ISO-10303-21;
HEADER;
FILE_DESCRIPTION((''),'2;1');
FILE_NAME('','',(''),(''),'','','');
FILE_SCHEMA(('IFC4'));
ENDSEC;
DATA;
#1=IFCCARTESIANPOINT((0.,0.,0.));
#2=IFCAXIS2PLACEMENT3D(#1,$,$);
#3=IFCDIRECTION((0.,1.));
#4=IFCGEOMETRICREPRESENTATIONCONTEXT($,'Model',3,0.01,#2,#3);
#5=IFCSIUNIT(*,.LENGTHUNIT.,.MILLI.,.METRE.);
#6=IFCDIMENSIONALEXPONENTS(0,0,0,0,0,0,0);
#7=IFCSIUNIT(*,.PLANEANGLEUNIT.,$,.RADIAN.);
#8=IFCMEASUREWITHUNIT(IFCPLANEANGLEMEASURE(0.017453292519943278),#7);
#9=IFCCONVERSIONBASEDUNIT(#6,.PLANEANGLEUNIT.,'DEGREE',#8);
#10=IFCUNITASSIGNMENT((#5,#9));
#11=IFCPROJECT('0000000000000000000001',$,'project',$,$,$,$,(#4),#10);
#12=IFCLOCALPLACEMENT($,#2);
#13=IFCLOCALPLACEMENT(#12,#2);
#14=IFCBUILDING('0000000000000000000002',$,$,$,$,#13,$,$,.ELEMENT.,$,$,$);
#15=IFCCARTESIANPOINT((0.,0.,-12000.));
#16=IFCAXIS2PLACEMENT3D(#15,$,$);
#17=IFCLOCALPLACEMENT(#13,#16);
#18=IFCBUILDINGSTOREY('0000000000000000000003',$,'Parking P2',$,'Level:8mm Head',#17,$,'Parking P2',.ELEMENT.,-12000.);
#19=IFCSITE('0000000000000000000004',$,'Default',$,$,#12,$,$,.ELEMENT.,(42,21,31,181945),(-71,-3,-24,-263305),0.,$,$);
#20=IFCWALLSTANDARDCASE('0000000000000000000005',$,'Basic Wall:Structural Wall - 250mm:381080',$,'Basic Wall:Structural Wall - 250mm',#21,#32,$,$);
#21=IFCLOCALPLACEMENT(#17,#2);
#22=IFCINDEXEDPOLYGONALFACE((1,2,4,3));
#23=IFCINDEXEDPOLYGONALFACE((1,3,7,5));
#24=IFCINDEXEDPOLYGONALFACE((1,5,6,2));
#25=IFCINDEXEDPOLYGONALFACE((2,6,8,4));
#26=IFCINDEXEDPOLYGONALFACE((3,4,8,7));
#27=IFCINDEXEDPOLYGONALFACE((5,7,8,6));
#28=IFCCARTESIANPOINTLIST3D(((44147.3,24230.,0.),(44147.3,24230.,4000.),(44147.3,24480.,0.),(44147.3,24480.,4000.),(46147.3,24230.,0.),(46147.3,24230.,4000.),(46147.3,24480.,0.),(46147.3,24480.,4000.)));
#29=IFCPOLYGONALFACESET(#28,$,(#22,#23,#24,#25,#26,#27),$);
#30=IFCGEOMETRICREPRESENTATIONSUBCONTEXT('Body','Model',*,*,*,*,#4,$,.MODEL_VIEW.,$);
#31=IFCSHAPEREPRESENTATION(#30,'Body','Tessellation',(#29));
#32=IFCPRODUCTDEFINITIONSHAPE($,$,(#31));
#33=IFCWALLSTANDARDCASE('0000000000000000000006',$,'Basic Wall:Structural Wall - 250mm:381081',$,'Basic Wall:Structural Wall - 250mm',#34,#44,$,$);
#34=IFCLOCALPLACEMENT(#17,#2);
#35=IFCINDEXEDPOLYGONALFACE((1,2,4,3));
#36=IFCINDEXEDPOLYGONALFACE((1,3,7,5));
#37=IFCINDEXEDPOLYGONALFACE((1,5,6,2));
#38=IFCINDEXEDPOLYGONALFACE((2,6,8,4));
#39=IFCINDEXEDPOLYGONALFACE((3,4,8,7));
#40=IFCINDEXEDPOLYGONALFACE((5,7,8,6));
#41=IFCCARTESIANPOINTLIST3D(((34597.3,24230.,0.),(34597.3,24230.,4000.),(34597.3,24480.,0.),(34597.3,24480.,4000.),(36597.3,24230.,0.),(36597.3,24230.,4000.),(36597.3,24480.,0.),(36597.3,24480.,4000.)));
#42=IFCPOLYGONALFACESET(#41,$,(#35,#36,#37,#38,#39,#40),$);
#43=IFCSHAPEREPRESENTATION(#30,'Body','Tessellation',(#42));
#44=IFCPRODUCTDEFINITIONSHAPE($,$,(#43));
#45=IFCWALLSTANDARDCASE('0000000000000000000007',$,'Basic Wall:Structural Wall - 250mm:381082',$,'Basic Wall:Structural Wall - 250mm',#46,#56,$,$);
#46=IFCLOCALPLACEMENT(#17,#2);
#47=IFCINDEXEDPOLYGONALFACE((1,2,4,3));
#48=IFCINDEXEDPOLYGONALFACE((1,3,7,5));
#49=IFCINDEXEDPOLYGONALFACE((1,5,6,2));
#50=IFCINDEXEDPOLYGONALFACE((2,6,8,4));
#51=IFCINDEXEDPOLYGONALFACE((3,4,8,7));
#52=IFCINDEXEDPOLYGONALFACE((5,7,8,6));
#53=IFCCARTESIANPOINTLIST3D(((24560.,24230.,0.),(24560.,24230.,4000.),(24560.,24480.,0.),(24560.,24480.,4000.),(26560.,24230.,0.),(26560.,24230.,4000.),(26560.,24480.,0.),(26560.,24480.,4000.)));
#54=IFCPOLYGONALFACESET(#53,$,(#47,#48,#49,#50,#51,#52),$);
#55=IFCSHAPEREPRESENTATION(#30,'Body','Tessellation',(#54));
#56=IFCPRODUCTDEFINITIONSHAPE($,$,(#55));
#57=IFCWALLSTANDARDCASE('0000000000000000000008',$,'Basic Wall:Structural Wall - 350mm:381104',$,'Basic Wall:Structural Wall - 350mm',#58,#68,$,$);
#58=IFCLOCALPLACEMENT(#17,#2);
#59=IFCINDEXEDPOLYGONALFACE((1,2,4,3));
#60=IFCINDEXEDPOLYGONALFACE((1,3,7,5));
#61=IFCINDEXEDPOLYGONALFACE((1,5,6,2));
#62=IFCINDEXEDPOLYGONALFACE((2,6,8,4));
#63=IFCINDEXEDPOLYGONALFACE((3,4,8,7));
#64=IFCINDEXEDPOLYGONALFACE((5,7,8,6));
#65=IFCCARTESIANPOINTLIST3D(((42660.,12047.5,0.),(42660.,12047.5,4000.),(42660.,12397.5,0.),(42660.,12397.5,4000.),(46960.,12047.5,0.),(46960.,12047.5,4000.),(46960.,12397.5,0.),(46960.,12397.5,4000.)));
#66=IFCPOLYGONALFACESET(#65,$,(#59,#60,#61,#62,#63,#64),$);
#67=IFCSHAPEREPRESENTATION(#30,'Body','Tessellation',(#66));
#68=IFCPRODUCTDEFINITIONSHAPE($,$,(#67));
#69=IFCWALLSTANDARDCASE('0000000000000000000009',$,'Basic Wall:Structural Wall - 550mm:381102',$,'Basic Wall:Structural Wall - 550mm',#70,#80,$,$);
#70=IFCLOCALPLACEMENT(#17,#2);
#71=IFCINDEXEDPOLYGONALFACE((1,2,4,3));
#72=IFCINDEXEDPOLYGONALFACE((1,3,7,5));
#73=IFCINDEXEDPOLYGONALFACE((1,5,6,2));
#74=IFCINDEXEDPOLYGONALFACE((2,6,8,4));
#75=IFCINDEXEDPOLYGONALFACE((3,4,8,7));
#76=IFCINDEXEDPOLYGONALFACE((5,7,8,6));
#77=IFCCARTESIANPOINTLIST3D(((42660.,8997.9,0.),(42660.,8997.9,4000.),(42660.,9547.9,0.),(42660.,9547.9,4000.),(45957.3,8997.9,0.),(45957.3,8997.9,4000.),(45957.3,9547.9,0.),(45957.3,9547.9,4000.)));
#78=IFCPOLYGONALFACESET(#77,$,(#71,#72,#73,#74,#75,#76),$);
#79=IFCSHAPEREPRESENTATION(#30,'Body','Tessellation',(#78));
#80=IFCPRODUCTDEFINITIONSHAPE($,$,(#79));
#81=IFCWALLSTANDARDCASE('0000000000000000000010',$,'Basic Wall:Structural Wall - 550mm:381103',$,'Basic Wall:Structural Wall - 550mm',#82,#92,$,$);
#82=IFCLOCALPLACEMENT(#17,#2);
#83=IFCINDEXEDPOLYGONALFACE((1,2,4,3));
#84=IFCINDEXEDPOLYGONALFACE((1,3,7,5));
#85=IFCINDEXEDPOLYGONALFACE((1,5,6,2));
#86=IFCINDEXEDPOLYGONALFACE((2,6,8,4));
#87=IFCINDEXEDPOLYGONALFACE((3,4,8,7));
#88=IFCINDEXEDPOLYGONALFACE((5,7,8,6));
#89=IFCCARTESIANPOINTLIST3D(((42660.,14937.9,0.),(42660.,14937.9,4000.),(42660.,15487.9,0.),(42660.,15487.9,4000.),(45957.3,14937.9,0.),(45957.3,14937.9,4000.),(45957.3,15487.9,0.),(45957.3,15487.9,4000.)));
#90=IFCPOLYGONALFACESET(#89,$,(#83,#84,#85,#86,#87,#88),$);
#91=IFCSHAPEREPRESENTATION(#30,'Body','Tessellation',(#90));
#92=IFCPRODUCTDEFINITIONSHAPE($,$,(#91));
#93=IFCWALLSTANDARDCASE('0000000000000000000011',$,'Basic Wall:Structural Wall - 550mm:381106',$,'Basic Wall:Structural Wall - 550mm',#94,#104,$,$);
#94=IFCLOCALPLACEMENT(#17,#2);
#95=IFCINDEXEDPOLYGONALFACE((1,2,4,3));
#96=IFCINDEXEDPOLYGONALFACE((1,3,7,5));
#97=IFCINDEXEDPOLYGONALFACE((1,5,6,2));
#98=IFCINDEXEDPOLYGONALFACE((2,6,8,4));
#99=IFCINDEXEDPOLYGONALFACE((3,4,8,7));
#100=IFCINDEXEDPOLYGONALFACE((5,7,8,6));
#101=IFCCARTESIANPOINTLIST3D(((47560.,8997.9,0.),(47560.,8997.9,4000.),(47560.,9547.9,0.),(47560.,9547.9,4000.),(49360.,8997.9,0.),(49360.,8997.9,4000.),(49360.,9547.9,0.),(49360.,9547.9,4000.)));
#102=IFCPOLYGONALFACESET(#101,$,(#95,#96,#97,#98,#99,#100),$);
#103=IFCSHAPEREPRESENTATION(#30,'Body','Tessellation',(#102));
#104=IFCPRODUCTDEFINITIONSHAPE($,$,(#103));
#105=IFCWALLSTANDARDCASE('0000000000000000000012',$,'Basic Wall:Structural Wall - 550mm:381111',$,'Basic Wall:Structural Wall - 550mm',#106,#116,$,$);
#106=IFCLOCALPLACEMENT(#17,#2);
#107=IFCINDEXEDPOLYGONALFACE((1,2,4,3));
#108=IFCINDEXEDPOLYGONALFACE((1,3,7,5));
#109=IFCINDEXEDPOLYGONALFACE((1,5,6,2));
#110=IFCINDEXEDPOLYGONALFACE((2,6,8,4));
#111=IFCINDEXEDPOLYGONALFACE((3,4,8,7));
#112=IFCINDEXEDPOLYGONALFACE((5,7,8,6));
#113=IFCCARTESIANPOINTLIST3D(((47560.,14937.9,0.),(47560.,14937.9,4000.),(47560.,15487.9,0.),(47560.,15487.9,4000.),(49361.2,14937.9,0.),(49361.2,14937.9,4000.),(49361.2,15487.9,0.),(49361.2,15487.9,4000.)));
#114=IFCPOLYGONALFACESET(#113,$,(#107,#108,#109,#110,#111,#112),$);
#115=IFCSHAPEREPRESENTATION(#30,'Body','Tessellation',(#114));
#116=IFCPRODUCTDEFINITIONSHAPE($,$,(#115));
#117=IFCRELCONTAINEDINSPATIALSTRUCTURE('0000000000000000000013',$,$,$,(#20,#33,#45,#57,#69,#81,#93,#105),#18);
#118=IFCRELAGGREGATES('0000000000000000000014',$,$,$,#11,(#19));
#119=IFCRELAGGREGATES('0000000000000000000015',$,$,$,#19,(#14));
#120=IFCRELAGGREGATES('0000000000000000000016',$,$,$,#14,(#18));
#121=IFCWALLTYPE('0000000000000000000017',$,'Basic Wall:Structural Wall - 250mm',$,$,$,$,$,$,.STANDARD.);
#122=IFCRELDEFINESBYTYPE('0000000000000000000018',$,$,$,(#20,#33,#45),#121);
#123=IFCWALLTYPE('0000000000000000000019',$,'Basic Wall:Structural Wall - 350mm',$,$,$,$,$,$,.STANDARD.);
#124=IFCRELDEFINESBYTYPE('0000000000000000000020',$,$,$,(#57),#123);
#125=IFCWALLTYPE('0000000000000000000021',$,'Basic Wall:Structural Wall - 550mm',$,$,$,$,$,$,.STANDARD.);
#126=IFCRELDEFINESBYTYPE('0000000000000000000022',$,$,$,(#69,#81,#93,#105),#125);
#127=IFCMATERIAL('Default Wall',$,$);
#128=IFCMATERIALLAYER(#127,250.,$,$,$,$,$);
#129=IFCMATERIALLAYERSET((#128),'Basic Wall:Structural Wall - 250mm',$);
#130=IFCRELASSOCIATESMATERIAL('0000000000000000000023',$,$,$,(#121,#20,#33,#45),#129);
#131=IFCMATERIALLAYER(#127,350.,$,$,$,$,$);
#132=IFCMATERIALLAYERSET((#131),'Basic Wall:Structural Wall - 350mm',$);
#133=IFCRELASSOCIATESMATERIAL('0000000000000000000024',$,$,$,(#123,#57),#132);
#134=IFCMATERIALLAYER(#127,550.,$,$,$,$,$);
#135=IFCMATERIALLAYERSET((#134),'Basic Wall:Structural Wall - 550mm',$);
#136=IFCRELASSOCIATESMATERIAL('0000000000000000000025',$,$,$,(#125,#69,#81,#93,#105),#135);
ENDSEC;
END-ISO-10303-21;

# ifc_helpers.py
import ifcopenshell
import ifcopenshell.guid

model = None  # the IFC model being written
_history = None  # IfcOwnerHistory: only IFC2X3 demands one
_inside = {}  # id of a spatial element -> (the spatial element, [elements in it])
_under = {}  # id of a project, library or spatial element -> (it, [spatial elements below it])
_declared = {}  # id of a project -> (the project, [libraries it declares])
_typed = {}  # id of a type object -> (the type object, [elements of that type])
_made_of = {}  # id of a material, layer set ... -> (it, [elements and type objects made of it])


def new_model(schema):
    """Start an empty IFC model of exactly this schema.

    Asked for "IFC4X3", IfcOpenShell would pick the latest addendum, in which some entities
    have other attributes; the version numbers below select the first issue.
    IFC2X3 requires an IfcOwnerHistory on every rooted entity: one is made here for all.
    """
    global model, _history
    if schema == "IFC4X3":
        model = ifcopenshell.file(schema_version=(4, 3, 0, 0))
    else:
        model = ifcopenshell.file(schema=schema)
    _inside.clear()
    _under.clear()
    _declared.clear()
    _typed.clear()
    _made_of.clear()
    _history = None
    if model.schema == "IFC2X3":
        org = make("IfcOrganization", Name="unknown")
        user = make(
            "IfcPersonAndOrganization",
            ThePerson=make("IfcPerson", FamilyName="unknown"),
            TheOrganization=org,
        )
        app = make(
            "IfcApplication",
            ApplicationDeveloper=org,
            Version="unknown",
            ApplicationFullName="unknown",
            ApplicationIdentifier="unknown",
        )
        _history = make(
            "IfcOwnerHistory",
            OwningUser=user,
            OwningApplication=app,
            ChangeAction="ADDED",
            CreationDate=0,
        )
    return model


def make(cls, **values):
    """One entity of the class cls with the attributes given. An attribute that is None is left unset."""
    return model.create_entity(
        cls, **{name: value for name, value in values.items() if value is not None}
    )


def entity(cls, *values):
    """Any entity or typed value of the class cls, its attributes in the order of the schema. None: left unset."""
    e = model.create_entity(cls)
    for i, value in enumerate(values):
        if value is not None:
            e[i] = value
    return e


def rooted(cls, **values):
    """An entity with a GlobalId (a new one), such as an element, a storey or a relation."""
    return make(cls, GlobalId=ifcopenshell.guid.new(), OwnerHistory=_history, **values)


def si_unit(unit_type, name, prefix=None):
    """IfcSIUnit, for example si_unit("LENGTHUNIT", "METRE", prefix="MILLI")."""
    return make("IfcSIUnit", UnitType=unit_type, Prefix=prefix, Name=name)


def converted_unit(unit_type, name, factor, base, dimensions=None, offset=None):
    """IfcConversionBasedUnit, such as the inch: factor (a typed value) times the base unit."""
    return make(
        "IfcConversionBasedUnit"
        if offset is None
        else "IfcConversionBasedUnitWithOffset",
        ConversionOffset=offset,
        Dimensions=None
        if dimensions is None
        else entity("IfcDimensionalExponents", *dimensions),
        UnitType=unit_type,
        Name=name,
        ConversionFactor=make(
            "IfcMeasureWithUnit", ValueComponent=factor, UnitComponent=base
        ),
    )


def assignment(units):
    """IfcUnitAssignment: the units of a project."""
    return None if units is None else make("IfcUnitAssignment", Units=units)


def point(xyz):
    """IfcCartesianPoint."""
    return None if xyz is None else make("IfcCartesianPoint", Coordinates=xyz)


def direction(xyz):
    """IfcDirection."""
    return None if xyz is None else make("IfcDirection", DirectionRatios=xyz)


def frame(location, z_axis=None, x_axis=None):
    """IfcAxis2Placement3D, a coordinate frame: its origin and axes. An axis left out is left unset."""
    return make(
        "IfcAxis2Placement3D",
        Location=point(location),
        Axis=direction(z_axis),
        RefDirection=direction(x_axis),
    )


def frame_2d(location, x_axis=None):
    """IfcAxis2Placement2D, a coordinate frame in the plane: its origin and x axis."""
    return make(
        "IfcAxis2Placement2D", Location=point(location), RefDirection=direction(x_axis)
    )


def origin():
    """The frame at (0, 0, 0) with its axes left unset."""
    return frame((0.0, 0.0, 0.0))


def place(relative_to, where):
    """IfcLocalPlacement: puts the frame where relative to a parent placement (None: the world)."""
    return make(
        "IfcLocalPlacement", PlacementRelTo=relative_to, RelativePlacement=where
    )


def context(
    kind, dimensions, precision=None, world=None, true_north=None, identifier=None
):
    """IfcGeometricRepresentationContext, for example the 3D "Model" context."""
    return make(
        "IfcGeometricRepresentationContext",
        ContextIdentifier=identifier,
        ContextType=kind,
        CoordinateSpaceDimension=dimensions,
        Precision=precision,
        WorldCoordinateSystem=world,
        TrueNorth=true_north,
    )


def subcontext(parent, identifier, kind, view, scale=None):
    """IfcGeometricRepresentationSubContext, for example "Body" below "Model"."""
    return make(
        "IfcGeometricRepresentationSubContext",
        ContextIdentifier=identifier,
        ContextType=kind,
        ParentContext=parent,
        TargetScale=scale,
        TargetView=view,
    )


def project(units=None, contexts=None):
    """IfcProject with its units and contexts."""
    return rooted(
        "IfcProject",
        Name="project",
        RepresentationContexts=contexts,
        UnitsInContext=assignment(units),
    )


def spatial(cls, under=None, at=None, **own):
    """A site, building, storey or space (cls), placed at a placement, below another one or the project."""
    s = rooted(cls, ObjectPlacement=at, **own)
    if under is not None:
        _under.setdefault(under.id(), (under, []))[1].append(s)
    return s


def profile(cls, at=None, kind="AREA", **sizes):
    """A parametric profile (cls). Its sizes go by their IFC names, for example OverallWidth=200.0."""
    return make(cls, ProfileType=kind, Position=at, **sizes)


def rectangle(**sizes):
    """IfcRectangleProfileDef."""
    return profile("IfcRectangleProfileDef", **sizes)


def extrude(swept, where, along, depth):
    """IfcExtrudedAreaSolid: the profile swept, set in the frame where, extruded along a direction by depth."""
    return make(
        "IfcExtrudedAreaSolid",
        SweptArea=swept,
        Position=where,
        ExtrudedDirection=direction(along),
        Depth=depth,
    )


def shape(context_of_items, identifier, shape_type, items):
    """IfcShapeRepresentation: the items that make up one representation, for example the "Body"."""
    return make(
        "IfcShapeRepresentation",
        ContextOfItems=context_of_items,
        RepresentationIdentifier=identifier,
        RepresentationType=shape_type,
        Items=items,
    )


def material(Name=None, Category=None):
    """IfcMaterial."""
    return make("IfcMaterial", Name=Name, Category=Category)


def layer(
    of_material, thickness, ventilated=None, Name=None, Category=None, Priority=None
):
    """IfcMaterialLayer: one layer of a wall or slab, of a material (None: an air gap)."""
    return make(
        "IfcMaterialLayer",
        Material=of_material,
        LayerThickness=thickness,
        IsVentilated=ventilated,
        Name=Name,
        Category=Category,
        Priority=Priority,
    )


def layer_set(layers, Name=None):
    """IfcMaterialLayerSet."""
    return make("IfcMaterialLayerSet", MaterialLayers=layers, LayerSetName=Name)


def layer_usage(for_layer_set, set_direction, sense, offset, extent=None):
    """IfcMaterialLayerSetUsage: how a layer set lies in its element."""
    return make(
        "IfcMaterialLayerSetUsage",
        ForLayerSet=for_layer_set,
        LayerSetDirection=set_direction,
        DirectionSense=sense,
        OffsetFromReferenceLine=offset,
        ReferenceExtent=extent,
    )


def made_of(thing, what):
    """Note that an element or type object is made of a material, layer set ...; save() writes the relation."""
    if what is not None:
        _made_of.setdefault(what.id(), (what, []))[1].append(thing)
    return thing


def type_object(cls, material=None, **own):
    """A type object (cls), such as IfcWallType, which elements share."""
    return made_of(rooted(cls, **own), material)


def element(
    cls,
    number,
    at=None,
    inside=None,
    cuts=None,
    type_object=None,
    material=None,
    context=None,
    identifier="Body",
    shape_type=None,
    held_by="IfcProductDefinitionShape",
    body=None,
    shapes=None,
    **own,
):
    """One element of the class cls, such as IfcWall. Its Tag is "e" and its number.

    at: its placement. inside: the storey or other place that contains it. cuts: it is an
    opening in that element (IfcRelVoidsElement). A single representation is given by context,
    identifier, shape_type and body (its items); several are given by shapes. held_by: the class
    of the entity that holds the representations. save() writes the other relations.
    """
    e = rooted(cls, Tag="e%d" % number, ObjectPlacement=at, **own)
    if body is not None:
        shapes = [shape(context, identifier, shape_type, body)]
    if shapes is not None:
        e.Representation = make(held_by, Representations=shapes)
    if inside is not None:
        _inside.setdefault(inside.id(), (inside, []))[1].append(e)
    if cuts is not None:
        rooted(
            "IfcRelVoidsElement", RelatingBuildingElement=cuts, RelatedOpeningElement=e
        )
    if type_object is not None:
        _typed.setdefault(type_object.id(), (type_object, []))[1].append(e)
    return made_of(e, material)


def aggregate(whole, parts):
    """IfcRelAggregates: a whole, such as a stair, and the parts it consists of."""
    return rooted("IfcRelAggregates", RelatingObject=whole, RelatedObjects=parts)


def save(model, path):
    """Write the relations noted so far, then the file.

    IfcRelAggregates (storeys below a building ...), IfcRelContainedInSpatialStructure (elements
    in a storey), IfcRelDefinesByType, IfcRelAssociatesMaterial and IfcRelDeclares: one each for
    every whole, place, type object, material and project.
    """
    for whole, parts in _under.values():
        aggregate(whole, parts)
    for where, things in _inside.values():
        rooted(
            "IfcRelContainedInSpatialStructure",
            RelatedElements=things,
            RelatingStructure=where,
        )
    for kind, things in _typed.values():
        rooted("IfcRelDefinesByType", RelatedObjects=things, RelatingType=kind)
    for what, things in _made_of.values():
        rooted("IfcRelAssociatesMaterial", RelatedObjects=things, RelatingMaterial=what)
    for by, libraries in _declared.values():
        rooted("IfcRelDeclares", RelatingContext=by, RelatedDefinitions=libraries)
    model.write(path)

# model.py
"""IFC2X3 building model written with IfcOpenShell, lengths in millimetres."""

from ifc_helpers import new_model, entity, si_unit, converted_unit, direction, frame, frame_2d, origin, place, context, subcontext, project, spatial, rectangle, extrude, material, layer, layer_set, layer_usage, type_object, element, save


model = new_model("IFC2X3")

# Units and contexts
model_context = context("Model", 3, precision=0.01, world=origin(), true_north=direction((0.0, 1.0)))
body_context = subcontext(model_context, "Body", "Model", "MODEL_VIEW")
ifc_project = project(units=[si_unit("LENGTHUNIT", "METRE", prefix="MILLI"), converted_unit("PLANEANGLEUNIT", "DEGREE", entity("IfcPlaneAngleMeasure", 0.017453292519943278), si_unit("PLANEANGLEUNIT", "RADIAN"), dimensions=[0, 0, 0, 0, 0, 0, 0])], contexts=[model_context])

# Site, building, storey
site_placement = place(None, origin())
site = spatial("IfcSite", under=ifc_project, at=site_placement, Name="Default", CompositionType="ELEMENT", RefLatitude=(42, 21, 31, 181945), RefLongitude=(-71, -3, -24, -263305), RefElevation=0.0)
building_placement = place(site_placement, origin())
building = spatial("IfcBuilding", under=site, at=building_placement, CompositionType="ELEMENT")
storey_placement = place(building_placement, frame((0.0, 0.0, -12000.0)))
storey = spatial("IfcBuildingStorey", under=building, at=storey_placement, Name="Parking P2", ObjectType="Level:8mm Head", LongName="Parking P2", CompositionType="ELEMENT", Elevation=-12000.0)

# Walls
ifc_material_1 = material(Name="Default Wall")
ifc_layer_1 = layer(ifc_material_1, 250.0)
ifc_layer_set_1 = layer_set([ifc_layer_1], Name="Basic Wall:Structural Wall - 250mm")
wall_type_1 = type_object("IfcWallType", Name="Basic Wall:Structural Wall - 250mm", PredefinedType="STANDARD", material=ifc_layer_set_1)
ifc_layer_usage_1 = layer_usage(ifc_layer_set_1, "AXIS2", "NEGATIVE", 125.0)
wall_1_placement = place(storey_placement, frame((44147.3, 24355.0, 0.0)))
element("IfcWallStandardCase", 1, at=wall_1_placement, inside=storey, type_object=wall_type_1, material=ifc_layer_usage_1, Name="Basic Wall:Structural Wall - 250mm:381080", ObjectType="Basic Wall:Structural Wall - 250mm", context=body_context, shape_type="SweptSolid", body=[
    extrude(rectangle(XDim=2000.0, YDim=250.0, at=frame_2d((1000.0, 0.0), x_axis=(-1.0, 0.0))), origin(), (0.0, 0.0, 1.0), 4000.0),
])
ifc_layer_usage_2 = layer_usage(ifc_layer_set_1, "AXIS2", "NEGATIVE", 125.0)
wall_2_placement = place(storey_placement, frame((34597.3, 24355.0, 0.0)))
element("IfcWallStandardCase", 2, at=wall_2_placement, inside=storey, type_object=wall_type_1, material=ifc_layer_usage_2, Name="Basic Wall:Structural Wall - 250mm:381081", ObjectType="Basic Wall:Structural Wall - 250mm", context=body_context, shape_type="SweptSolid", body=[
    extrude(rectangle(XDim=2000.0, YDim=250.0, at=frame_2d((1000.0, 0.0), x_axis=(-1.0, 0.0))), origin(), (0.0, 0.0, 1.0), 4000.0),
])
ifc_layer_usage_3 = layer_usage(ifc_layer_set_1, "AXIS2", "NEGATIVE", 125.0)
wall_3_placement = place(storey_placement, frame((24560.0, 24355.0, 0.0)))
element("IfcWallStandardCase", 3, at=wall_3_placement, inside=storey, type_object=wall_type_1, material=ifc_layer_usage_3, Name="Basic Wall:Structural Wall - 250mm:381082", ObjectType="Basic Wall:Structural Wall - 250mm", context=body_context, shape_type="SweptSolid", body=[
    extrude(rectangle(XDim=2000.0, YDim=250.0, at=frame_2d((1000.0, 0.0), x_axis=(-1.0, 0.0))), origin(), (0.0, 0.0, 1.0), 4000.0),
])
ifc_layer_2 = layer(ifc_material_1, 350.0)
ifc_layer_set_2 = layer_set([ifc_layer_2], Name="Basic Wall:Structural Wall - 350mm")
ifc_layer_usage_4 = layer_usage(ifc_layer_set_2, "AXIS2", "NEGATIVE", 175.0)
wall_type_2 = type_object("IfcWallType", Name="Basic Wall:Structural Wall - 350mm", PredefinedType="STANDARD", material=ifc_layer_set_2)
wall_4_placement = place(storey_placement, frame((42660.0, 12222.5, 0.0)))
element("IfcWallStandardCase", 4, at=wall_4_placement, inside=storey, type_object=wall_type_2, material=ifc_layer_usage_4, Name="Basic Wall:Structural Wall - 350mm:381104", ObjectType="Basic Wall:Structural Wall - 350mm", context=body_context, shape_type="SweptSolid", body=[
    extrude(rectangle(XDim=4300.0, YDim=350.0, at=frame_2d((2150.0, 0.0), x_axis=(-1.0, 0.0))), origin(), (0.0, 0.0, 1.0), 4000.0),
])
ifc_layer_3 = layer(ifc_material_1, 550.0)
ifc_layer_set_3 = layer_set([ifc_layer_3], Name="Basic Wall:Structural Wall - 550mm")
ifc_layer_usage_5 = layer_usage(ifc_layer_set_3, "AXIS2", "NEGATIVE", 275.0)
wall_type_3 = type_object("IfcWallType", Name="Basic Wall:Structural Wall - 550mm", PredefinedType="STANDARD", material=ifc_layer_set_3)
wall_5_placement = place(storey_placement, frame((42660.0, 9272.9, 0.0)))
element("IfcWallStandardCase", 5, at=wall_5_placement, inside=storey, type_object=wall_type_3, material=ifc_layer_usage_5, Name="Basic Wall:Structural Wall - 550mm:381102", ObjectType="Basic Wall:Structural Wall - 550mm", context=body_context, shape_type="SweptSolid", body=[
    extrude(rectangle(XDim=3297.3, YDim=550.0, at=frame_2d((1648.6, 0.0), x_axis=(-1.0, 0.0))), origin(), (0.0, 0.0, 1.0), 4000.0),
])
ifc_layer_usage_6 = layer_usage(ifc_layer_set_3, "AXIS2", "NEGATIVE", 275.0)
wall_6_placement = place(storey_placement, frame((45957.3, 15212.9, 0.0), z_axis=(0.0, 0.0, 1.0), x_axis=(-1.0, 0.0, 0.0)))
element("IfcWallStandardCase", 6, at=wall_6_placement, inside=storey, type_object=wall_type_3, material=ifc_layer_usage_6, Name="Basic Wall:Structural Wall - 550mm:381103", ObjectType="Basic Wall:Structural Wall - 550mm", context=body_context, shape_type="SweptSolid", body=[
    extrude(rectangle(XDim=3297.3, YDim=550.0, at=frame_2d((1648.6, 0.0), x_axis=(-1.0, 0.0))), origin(), (0.0, 0.0, 1.0), 4000.0),
])
ifc_layer_usage_7 = layer_usage(ifc_layer_set_3, "AXIS2", "NEGATIVE", 275.0)
wall_7_placement = place(storey_placement, frame((47560.0, 9272.9, 0.0)))
element("IfcWallStandardCase", 7, at=wall_7_placement, inside=storey, type_object=wall_type_3, material=ifc_layer_usage_7, Name="Basic Wall:Structural Wall - 550mm:381106", ObjectType="Basic Wall:Structural Wall - 550mm", context=body_context, shape_type="SweptSolid", body=[
    extrude(rectangle(XDim=1800.0, YDim=550.0, at=frame_2d((900.0, 0.0), x_axis=(-1.0, 0.0))), origin(), (0.0, 0.0, 1.0), 4000.0),
])
ifc_layer_usage_8 = layer_usage(ifc_layer_set_3, "AXIS2", "NEGATIVE", 275.0)
wall_8_placement = place(storey_placement, frame((49361.2, 15212.9, 0.0), z_axis=(0.0, 0.0, 1.0), x_axis=(-1.0, 0.0, 0.0)))
element("IfcWallStandardCase", 8, at=wall_8_placement, inside=storey, type_object=wall_type_3, material=ifc_layer_usage_8, Name="Basic Wall:Structural Wall - 550mm:381111", ObjectType="Basic Wall:Structural Wall - 550mm", context=body_context, shape_type="SweptSolid", body=[
    extrude(rectangle(XDim=1801.2, YDim=550.0, at=frame_2d((900.6, 0.0), x_axis=(-1.0, 0.0))), origin(), (0.0, 0.0, 1.0), 4000.0),
])

save(model, "model.ifc")
